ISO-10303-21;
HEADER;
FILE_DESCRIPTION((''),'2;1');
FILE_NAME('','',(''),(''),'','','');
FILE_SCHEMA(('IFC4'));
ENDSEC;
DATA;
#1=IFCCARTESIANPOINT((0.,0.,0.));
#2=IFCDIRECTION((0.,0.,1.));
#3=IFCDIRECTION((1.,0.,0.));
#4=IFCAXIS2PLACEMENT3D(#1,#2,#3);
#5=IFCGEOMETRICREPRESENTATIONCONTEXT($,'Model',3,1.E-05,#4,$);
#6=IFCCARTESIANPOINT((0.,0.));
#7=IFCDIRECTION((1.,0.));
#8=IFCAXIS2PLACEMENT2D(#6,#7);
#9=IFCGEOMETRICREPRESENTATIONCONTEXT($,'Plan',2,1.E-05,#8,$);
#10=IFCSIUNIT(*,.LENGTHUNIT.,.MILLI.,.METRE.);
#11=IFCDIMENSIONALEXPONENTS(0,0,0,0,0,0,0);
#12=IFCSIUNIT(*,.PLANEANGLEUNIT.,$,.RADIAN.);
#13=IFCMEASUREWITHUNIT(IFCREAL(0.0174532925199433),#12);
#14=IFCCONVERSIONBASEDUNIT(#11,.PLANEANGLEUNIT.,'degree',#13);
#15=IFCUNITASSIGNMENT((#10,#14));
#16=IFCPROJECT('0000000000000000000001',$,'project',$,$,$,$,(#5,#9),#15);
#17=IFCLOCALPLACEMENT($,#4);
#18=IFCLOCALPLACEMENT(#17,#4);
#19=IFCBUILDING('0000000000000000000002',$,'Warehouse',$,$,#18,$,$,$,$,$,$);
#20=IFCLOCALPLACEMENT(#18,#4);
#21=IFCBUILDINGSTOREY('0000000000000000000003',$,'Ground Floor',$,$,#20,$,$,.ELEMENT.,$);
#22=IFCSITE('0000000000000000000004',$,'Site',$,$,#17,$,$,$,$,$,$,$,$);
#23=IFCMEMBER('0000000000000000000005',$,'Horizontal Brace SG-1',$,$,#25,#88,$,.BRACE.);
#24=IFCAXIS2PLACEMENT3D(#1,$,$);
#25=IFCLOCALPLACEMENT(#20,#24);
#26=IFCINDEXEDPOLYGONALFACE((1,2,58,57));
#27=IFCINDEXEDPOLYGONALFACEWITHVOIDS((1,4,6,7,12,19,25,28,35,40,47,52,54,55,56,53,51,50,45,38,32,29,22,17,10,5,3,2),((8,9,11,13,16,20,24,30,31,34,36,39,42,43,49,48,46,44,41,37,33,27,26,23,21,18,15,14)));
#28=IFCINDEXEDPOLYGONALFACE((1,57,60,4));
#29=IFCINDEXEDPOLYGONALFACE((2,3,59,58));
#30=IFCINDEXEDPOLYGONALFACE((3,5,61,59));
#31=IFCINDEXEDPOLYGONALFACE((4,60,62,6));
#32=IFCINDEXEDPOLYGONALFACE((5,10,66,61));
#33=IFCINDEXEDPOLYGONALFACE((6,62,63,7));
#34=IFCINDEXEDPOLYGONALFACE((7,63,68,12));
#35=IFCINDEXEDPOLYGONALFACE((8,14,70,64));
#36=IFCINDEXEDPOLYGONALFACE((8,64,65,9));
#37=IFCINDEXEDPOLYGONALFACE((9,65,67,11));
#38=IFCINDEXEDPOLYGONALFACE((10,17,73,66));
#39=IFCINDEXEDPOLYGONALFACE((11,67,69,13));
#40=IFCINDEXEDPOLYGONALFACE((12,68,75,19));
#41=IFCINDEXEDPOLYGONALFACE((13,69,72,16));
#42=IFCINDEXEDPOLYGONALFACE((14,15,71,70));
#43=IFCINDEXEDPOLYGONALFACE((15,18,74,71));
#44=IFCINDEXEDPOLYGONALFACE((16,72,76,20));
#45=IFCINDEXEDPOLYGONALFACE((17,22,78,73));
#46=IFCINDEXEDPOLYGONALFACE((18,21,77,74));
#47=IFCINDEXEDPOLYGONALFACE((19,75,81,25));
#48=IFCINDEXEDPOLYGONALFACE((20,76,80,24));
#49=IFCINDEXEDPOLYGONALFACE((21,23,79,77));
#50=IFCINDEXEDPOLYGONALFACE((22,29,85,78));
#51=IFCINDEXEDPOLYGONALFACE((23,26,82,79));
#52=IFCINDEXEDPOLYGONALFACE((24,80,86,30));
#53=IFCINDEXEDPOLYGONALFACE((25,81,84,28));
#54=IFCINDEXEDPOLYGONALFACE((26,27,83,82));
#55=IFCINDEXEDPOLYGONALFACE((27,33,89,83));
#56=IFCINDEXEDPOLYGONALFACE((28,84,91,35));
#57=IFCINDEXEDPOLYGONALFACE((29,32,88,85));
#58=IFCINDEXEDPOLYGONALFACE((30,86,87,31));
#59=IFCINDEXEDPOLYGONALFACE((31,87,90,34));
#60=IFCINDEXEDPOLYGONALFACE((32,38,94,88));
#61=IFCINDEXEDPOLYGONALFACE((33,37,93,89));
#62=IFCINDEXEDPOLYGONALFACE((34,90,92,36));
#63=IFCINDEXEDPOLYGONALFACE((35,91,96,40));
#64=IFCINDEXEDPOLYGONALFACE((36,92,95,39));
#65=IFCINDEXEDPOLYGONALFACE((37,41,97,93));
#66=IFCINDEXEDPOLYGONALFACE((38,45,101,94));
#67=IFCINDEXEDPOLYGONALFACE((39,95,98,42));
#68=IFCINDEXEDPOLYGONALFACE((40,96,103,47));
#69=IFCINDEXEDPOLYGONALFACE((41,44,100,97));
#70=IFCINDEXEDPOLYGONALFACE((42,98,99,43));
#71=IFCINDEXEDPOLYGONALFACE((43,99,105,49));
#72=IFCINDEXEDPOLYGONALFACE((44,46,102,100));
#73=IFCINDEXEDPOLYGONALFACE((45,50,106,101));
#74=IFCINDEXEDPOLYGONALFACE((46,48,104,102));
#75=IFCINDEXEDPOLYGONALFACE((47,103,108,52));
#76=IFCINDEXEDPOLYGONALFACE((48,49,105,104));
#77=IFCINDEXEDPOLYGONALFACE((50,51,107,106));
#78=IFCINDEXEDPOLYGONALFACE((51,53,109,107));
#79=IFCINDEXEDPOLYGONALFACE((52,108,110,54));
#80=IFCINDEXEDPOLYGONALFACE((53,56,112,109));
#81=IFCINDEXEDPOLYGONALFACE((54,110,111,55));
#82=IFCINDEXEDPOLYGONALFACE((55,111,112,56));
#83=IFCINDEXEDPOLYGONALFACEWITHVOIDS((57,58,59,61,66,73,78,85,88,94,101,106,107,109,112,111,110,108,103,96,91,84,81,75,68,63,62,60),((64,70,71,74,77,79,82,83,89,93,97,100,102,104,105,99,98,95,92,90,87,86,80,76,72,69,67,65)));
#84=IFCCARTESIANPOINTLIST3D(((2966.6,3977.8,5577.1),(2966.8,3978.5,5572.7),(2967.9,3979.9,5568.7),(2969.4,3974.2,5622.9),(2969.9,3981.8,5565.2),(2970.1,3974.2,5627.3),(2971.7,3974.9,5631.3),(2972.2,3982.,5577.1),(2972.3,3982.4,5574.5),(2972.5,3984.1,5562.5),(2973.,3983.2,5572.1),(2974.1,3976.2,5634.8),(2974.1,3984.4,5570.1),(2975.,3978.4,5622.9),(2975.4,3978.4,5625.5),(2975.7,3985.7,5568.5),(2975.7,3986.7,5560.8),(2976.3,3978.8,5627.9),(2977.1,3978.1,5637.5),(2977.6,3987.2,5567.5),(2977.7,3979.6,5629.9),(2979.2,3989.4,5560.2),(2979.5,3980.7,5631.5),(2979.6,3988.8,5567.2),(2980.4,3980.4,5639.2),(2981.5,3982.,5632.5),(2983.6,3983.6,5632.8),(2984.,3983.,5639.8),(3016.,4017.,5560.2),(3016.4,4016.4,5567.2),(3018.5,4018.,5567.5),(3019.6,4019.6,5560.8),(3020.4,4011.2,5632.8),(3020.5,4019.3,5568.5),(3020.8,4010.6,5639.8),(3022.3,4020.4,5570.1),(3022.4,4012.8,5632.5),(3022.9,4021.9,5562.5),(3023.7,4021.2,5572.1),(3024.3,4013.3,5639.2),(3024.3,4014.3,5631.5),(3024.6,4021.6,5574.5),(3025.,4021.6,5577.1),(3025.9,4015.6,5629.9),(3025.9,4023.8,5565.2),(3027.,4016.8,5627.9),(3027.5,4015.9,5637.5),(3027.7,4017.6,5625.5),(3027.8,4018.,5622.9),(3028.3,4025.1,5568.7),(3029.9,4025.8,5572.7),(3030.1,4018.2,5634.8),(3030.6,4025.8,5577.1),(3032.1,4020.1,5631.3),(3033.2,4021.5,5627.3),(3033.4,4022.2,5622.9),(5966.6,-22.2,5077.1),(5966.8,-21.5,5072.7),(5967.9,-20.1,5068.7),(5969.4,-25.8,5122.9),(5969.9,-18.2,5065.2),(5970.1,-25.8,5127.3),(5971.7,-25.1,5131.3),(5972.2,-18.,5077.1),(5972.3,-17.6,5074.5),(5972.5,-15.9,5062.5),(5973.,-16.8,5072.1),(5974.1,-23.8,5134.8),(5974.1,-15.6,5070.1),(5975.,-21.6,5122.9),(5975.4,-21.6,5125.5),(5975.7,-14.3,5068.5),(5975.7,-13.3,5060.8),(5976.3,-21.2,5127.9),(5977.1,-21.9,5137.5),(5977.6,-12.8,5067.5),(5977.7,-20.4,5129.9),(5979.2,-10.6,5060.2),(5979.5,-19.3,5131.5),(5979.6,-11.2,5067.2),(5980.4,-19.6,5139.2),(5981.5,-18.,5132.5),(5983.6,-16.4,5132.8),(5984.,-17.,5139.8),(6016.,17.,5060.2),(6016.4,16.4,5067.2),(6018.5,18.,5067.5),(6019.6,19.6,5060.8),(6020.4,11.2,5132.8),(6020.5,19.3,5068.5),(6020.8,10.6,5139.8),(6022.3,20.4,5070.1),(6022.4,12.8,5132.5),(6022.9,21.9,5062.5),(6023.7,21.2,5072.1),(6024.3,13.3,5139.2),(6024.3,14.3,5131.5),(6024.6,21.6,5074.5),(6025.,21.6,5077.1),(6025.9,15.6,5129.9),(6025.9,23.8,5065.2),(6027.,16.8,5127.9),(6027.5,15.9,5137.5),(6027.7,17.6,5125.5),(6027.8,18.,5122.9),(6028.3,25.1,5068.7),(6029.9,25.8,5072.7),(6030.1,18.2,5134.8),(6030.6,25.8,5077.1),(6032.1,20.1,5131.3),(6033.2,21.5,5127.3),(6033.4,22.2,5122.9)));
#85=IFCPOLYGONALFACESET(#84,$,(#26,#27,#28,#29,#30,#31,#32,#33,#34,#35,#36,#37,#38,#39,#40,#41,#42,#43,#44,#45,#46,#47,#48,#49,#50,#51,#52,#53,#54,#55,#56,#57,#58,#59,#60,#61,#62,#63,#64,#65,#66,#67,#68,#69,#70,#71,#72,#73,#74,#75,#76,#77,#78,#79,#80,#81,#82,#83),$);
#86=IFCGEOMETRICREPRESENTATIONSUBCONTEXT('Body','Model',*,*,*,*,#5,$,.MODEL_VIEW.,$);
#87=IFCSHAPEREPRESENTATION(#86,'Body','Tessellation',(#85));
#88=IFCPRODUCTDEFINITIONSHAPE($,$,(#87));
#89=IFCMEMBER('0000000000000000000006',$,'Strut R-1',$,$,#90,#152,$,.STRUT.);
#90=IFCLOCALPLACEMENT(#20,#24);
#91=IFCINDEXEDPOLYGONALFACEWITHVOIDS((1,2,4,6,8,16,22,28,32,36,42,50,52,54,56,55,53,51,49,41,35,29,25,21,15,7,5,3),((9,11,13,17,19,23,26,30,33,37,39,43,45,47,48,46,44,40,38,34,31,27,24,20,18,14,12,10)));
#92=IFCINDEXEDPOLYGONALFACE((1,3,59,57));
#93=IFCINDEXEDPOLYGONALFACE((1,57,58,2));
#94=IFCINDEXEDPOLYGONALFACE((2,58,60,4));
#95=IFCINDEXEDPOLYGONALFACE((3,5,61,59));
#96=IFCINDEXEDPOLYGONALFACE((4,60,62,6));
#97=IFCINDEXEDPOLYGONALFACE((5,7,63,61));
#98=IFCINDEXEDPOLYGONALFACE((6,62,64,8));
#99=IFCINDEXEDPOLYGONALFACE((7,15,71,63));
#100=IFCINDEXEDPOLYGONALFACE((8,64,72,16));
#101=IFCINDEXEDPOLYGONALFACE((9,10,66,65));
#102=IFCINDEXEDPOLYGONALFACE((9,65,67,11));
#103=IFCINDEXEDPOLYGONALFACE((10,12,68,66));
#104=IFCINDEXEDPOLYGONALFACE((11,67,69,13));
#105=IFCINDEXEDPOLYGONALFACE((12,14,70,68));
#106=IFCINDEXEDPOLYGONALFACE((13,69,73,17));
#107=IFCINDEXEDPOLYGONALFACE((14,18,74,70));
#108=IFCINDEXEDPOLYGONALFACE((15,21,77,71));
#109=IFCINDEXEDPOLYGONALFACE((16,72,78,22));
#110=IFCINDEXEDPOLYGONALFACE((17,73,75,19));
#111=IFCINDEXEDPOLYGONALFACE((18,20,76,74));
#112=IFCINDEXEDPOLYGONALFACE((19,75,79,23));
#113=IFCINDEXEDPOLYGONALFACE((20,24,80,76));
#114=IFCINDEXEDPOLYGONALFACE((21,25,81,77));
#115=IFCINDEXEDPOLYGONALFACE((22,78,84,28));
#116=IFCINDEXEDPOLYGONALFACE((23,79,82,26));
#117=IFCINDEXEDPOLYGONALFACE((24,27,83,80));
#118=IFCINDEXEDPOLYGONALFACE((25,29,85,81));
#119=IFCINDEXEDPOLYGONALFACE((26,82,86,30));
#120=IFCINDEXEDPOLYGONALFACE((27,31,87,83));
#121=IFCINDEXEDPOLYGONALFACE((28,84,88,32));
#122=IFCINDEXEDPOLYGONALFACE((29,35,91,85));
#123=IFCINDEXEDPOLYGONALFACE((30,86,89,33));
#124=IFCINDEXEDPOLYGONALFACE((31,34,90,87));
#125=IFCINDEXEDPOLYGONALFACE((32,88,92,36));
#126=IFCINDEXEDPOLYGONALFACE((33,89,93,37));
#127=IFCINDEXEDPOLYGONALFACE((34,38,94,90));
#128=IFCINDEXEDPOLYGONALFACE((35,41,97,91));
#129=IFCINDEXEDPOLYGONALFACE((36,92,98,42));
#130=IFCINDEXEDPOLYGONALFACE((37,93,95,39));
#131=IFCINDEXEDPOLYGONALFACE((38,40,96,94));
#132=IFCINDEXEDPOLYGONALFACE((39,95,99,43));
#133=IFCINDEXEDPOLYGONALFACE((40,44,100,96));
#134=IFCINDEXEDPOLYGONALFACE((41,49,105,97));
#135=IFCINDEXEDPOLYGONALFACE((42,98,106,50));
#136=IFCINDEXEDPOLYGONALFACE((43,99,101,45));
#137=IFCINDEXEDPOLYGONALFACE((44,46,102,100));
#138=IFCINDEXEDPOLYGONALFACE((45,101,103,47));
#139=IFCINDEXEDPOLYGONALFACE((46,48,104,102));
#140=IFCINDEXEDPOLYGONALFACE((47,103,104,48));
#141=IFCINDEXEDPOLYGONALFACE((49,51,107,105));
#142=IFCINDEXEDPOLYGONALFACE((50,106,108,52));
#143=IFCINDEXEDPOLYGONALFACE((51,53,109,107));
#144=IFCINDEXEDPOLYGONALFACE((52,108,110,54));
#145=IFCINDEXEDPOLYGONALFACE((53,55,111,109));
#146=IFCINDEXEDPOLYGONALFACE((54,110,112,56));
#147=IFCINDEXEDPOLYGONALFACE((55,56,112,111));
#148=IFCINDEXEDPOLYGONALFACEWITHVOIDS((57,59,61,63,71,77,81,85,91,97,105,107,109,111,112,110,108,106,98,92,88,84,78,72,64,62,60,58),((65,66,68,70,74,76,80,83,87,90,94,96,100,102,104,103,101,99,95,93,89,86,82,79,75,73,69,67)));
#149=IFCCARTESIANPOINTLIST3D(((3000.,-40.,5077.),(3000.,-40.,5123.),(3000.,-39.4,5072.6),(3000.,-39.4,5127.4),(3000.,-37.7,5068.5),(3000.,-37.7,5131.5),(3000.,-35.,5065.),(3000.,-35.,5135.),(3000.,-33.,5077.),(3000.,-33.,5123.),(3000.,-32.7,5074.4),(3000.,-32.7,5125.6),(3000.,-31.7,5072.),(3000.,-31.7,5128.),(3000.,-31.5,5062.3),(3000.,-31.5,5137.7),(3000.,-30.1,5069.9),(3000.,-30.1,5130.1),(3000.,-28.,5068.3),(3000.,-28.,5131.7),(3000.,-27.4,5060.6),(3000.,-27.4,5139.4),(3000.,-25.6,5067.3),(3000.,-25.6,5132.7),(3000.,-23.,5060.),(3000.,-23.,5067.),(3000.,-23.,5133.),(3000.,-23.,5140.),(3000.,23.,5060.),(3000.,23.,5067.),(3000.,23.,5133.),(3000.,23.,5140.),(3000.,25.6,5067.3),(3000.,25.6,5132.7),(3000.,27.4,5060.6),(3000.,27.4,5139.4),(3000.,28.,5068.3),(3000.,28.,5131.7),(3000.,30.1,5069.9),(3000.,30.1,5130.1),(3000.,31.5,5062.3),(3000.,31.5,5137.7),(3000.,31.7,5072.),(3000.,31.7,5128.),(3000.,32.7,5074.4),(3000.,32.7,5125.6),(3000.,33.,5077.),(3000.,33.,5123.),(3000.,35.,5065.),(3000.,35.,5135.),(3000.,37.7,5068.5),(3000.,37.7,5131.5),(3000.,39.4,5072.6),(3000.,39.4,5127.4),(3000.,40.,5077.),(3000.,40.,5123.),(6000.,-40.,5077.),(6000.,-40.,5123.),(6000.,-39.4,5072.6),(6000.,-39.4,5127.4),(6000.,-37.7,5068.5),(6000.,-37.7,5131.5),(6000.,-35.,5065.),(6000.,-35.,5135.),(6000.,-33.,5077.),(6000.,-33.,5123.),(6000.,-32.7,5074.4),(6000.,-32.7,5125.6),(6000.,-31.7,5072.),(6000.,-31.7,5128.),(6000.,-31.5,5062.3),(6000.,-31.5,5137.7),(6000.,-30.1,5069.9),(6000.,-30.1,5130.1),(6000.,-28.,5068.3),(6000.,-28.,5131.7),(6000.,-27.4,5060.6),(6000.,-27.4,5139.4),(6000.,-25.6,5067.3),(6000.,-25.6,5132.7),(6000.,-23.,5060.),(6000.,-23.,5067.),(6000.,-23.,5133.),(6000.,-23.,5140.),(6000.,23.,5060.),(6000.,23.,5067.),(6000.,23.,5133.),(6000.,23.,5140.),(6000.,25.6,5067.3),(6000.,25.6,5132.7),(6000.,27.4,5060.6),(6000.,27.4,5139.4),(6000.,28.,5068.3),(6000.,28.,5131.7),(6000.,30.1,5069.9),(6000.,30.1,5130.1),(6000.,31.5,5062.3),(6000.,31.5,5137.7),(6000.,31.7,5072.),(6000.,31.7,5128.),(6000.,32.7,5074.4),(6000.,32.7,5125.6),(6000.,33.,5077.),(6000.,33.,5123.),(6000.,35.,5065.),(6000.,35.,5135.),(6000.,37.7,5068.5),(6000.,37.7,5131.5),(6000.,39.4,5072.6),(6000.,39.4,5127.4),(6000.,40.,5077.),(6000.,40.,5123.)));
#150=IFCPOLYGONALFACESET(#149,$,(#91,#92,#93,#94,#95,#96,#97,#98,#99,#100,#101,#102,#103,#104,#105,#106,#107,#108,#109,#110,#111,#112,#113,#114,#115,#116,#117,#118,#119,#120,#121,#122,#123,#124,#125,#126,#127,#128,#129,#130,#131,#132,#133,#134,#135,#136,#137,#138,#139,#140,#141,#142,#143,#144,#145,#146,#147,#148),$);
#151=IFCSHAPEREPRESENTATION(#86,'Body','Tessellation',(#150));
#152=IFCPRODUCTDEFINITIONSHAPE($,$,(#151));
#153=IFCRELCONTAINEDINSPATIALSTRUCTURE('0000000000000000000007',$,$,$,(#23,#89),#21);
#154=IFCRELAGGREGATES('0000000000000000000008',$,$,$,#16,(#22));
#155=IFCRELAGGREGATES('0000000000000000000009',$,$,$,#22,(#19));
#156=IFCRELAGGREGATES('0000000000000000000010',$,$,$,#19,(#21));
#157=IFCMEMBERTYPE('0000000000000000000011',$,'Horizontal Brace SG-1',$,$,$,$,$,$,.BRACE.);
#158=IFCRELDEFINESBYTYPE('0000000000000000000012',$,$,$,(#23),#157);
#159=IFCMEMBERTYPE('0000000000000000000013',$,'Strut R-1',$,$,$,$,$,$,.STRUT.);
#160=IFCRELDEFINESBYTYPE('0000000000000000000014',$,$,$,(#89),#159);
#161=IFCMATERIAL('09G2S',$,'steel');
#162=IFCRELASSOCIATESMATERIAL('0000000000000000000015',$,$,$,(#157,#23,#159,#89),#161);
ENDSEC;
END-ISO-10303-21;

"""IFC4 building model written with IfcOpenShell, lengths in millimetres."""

from ifc_helpers import new_model, entity, si_unit, converted_unit, frame, origin_with_axes, origin_2d_with_axis, place, context, subcontext, project, spatial, hollow_rectangle, extrude, material, material_profile, profile_set, profile_usage, type_object, element, save


model = new_model("IFC4")

# Units and contexts
model_context = context("Model", 3, precision=1e-05, world=origin_with_axes())
plan_context = context("Plan", 2, precision=1e-05, world=origin_2d_with_axis())
body_context = subcontext(model_context, "Body", "Model", "MODEL_VIEW")
ifc_project = project(units=[si_unit("LENGTHUNIT", "METRE", prefix="MILLI"), converted_unit("PLANEANGLEUNIT", "degree", entity("IfcReal", 0.0174532925199433), si_unit("PLANEANGLEUNIT", "RADIAN"), dimensions=[0, 0, 0, 0, 0, 0, 0])], contexts=[model_context, plan_context])

# Site, building, storey
site_placement = place(None, origin_with_axes())
site = spatial("IfcSite", under=ifc_project, at=site_placement, Name="Site")
building_placement = place(site_placement, origin_with_axes())
building = spatial("IfcBuilding", under=site, at=building_placement, Name="Warehouse")
storey_placement = place(building_placement, origin_with_axes())
storey = spatial("IfcBuildingStorey", under=building, at=storey_placement, Name="Ground Floor", CompositionType="ELEMENT")

# Members
ifc_material_1 = material(Name="09G2S", Category="steel")
ifc_material_profile_1 = material_profile(ifc_material_1, hollow_rectangle(XDim=80.0, YDim=80.0, WallThickness=7.0, InnerFilletRadius=10.0, OuterFilletRadius=17.0))
ifc_profile_set_1 = profile_set([ifc_material_profile_1], Name="PK80x7_09G2S")
ifc_profile_usage_1 = profile_usage(ifc_profile_set_1, cardinal=5)
member_type_1 = type_object("IfcMemberType", Name="Horizontal Brace SG-1", PredefinedType="BRACE", material=ifc_profile_set_1)
member_1_placement = place(storey_placement, frame((6000.0, 0.0, 5100.0), z_axis=(-0.597022, 0.79603, 0.099504), x_axis=(-0.8, -0.6, 0.0)))
element("IfcMember", 1, at=member_1_placement, inside=storey, type_object=member_type_1, material=ifc_profile_usage_1, Name="Horizontal Brace SG-1", PredefinedType="BRACE", context=body_context, shape_type="SweptSolid", body=[
    extrude(hollow_rectangle(XDim=80.0, YDim=80.0, WallThickness=7.0, InnerFilletRadius=10.0, OuterFilletRadius=17.0), origin_with_axes(), (0.0, 0.0, 1.0), 5024.9),
])
ifc_material_profile_2 = material_profile(ifc_material_1, hollow_rectangle(XDim=80.0, YDim=80.0, WallThickness=7.0, InnerFilletRadius=10.0, OuterFilletRadius=17.0))
ifc_profile_set_2 = profile_set([ifc_material_profile_2], Name="PK80x7_09G2S")
ifc_profile_usage_2 = profile_usage(ifc_profile_set_2, cardinal=5)
member_type_2 = type_object("IfcMemberType", Name="Strut R-1", PredefinedType="STRUT", material=ifc_profile_set_2)
member_2_placement = place(storey_placement, frame((3000.0, 0.0, 5100.0), z_axis=(1.0, 0.0, 0.0), x_axis=(0.0, 1.0, 0.0)))
element("IfcMember", 2, at=member_2_placement, inside=storey, type_object=member_type_2, material=ifc_profile_usage_2, Name="Strut R-1", PredefinedType="STRUT", context=body_context, shape_type="SweptSolid", body=[
    extrude(hollow_rectangle(XDim=80.0, YDim=80.0, WallThickness=7.0, InnerFilletRadius=10.0, OuterFilletRadius=17.0), origin_with_axes(), (0.0, 0.0, 1.0), 3000.0),
])

save(model, "model.ifc")
